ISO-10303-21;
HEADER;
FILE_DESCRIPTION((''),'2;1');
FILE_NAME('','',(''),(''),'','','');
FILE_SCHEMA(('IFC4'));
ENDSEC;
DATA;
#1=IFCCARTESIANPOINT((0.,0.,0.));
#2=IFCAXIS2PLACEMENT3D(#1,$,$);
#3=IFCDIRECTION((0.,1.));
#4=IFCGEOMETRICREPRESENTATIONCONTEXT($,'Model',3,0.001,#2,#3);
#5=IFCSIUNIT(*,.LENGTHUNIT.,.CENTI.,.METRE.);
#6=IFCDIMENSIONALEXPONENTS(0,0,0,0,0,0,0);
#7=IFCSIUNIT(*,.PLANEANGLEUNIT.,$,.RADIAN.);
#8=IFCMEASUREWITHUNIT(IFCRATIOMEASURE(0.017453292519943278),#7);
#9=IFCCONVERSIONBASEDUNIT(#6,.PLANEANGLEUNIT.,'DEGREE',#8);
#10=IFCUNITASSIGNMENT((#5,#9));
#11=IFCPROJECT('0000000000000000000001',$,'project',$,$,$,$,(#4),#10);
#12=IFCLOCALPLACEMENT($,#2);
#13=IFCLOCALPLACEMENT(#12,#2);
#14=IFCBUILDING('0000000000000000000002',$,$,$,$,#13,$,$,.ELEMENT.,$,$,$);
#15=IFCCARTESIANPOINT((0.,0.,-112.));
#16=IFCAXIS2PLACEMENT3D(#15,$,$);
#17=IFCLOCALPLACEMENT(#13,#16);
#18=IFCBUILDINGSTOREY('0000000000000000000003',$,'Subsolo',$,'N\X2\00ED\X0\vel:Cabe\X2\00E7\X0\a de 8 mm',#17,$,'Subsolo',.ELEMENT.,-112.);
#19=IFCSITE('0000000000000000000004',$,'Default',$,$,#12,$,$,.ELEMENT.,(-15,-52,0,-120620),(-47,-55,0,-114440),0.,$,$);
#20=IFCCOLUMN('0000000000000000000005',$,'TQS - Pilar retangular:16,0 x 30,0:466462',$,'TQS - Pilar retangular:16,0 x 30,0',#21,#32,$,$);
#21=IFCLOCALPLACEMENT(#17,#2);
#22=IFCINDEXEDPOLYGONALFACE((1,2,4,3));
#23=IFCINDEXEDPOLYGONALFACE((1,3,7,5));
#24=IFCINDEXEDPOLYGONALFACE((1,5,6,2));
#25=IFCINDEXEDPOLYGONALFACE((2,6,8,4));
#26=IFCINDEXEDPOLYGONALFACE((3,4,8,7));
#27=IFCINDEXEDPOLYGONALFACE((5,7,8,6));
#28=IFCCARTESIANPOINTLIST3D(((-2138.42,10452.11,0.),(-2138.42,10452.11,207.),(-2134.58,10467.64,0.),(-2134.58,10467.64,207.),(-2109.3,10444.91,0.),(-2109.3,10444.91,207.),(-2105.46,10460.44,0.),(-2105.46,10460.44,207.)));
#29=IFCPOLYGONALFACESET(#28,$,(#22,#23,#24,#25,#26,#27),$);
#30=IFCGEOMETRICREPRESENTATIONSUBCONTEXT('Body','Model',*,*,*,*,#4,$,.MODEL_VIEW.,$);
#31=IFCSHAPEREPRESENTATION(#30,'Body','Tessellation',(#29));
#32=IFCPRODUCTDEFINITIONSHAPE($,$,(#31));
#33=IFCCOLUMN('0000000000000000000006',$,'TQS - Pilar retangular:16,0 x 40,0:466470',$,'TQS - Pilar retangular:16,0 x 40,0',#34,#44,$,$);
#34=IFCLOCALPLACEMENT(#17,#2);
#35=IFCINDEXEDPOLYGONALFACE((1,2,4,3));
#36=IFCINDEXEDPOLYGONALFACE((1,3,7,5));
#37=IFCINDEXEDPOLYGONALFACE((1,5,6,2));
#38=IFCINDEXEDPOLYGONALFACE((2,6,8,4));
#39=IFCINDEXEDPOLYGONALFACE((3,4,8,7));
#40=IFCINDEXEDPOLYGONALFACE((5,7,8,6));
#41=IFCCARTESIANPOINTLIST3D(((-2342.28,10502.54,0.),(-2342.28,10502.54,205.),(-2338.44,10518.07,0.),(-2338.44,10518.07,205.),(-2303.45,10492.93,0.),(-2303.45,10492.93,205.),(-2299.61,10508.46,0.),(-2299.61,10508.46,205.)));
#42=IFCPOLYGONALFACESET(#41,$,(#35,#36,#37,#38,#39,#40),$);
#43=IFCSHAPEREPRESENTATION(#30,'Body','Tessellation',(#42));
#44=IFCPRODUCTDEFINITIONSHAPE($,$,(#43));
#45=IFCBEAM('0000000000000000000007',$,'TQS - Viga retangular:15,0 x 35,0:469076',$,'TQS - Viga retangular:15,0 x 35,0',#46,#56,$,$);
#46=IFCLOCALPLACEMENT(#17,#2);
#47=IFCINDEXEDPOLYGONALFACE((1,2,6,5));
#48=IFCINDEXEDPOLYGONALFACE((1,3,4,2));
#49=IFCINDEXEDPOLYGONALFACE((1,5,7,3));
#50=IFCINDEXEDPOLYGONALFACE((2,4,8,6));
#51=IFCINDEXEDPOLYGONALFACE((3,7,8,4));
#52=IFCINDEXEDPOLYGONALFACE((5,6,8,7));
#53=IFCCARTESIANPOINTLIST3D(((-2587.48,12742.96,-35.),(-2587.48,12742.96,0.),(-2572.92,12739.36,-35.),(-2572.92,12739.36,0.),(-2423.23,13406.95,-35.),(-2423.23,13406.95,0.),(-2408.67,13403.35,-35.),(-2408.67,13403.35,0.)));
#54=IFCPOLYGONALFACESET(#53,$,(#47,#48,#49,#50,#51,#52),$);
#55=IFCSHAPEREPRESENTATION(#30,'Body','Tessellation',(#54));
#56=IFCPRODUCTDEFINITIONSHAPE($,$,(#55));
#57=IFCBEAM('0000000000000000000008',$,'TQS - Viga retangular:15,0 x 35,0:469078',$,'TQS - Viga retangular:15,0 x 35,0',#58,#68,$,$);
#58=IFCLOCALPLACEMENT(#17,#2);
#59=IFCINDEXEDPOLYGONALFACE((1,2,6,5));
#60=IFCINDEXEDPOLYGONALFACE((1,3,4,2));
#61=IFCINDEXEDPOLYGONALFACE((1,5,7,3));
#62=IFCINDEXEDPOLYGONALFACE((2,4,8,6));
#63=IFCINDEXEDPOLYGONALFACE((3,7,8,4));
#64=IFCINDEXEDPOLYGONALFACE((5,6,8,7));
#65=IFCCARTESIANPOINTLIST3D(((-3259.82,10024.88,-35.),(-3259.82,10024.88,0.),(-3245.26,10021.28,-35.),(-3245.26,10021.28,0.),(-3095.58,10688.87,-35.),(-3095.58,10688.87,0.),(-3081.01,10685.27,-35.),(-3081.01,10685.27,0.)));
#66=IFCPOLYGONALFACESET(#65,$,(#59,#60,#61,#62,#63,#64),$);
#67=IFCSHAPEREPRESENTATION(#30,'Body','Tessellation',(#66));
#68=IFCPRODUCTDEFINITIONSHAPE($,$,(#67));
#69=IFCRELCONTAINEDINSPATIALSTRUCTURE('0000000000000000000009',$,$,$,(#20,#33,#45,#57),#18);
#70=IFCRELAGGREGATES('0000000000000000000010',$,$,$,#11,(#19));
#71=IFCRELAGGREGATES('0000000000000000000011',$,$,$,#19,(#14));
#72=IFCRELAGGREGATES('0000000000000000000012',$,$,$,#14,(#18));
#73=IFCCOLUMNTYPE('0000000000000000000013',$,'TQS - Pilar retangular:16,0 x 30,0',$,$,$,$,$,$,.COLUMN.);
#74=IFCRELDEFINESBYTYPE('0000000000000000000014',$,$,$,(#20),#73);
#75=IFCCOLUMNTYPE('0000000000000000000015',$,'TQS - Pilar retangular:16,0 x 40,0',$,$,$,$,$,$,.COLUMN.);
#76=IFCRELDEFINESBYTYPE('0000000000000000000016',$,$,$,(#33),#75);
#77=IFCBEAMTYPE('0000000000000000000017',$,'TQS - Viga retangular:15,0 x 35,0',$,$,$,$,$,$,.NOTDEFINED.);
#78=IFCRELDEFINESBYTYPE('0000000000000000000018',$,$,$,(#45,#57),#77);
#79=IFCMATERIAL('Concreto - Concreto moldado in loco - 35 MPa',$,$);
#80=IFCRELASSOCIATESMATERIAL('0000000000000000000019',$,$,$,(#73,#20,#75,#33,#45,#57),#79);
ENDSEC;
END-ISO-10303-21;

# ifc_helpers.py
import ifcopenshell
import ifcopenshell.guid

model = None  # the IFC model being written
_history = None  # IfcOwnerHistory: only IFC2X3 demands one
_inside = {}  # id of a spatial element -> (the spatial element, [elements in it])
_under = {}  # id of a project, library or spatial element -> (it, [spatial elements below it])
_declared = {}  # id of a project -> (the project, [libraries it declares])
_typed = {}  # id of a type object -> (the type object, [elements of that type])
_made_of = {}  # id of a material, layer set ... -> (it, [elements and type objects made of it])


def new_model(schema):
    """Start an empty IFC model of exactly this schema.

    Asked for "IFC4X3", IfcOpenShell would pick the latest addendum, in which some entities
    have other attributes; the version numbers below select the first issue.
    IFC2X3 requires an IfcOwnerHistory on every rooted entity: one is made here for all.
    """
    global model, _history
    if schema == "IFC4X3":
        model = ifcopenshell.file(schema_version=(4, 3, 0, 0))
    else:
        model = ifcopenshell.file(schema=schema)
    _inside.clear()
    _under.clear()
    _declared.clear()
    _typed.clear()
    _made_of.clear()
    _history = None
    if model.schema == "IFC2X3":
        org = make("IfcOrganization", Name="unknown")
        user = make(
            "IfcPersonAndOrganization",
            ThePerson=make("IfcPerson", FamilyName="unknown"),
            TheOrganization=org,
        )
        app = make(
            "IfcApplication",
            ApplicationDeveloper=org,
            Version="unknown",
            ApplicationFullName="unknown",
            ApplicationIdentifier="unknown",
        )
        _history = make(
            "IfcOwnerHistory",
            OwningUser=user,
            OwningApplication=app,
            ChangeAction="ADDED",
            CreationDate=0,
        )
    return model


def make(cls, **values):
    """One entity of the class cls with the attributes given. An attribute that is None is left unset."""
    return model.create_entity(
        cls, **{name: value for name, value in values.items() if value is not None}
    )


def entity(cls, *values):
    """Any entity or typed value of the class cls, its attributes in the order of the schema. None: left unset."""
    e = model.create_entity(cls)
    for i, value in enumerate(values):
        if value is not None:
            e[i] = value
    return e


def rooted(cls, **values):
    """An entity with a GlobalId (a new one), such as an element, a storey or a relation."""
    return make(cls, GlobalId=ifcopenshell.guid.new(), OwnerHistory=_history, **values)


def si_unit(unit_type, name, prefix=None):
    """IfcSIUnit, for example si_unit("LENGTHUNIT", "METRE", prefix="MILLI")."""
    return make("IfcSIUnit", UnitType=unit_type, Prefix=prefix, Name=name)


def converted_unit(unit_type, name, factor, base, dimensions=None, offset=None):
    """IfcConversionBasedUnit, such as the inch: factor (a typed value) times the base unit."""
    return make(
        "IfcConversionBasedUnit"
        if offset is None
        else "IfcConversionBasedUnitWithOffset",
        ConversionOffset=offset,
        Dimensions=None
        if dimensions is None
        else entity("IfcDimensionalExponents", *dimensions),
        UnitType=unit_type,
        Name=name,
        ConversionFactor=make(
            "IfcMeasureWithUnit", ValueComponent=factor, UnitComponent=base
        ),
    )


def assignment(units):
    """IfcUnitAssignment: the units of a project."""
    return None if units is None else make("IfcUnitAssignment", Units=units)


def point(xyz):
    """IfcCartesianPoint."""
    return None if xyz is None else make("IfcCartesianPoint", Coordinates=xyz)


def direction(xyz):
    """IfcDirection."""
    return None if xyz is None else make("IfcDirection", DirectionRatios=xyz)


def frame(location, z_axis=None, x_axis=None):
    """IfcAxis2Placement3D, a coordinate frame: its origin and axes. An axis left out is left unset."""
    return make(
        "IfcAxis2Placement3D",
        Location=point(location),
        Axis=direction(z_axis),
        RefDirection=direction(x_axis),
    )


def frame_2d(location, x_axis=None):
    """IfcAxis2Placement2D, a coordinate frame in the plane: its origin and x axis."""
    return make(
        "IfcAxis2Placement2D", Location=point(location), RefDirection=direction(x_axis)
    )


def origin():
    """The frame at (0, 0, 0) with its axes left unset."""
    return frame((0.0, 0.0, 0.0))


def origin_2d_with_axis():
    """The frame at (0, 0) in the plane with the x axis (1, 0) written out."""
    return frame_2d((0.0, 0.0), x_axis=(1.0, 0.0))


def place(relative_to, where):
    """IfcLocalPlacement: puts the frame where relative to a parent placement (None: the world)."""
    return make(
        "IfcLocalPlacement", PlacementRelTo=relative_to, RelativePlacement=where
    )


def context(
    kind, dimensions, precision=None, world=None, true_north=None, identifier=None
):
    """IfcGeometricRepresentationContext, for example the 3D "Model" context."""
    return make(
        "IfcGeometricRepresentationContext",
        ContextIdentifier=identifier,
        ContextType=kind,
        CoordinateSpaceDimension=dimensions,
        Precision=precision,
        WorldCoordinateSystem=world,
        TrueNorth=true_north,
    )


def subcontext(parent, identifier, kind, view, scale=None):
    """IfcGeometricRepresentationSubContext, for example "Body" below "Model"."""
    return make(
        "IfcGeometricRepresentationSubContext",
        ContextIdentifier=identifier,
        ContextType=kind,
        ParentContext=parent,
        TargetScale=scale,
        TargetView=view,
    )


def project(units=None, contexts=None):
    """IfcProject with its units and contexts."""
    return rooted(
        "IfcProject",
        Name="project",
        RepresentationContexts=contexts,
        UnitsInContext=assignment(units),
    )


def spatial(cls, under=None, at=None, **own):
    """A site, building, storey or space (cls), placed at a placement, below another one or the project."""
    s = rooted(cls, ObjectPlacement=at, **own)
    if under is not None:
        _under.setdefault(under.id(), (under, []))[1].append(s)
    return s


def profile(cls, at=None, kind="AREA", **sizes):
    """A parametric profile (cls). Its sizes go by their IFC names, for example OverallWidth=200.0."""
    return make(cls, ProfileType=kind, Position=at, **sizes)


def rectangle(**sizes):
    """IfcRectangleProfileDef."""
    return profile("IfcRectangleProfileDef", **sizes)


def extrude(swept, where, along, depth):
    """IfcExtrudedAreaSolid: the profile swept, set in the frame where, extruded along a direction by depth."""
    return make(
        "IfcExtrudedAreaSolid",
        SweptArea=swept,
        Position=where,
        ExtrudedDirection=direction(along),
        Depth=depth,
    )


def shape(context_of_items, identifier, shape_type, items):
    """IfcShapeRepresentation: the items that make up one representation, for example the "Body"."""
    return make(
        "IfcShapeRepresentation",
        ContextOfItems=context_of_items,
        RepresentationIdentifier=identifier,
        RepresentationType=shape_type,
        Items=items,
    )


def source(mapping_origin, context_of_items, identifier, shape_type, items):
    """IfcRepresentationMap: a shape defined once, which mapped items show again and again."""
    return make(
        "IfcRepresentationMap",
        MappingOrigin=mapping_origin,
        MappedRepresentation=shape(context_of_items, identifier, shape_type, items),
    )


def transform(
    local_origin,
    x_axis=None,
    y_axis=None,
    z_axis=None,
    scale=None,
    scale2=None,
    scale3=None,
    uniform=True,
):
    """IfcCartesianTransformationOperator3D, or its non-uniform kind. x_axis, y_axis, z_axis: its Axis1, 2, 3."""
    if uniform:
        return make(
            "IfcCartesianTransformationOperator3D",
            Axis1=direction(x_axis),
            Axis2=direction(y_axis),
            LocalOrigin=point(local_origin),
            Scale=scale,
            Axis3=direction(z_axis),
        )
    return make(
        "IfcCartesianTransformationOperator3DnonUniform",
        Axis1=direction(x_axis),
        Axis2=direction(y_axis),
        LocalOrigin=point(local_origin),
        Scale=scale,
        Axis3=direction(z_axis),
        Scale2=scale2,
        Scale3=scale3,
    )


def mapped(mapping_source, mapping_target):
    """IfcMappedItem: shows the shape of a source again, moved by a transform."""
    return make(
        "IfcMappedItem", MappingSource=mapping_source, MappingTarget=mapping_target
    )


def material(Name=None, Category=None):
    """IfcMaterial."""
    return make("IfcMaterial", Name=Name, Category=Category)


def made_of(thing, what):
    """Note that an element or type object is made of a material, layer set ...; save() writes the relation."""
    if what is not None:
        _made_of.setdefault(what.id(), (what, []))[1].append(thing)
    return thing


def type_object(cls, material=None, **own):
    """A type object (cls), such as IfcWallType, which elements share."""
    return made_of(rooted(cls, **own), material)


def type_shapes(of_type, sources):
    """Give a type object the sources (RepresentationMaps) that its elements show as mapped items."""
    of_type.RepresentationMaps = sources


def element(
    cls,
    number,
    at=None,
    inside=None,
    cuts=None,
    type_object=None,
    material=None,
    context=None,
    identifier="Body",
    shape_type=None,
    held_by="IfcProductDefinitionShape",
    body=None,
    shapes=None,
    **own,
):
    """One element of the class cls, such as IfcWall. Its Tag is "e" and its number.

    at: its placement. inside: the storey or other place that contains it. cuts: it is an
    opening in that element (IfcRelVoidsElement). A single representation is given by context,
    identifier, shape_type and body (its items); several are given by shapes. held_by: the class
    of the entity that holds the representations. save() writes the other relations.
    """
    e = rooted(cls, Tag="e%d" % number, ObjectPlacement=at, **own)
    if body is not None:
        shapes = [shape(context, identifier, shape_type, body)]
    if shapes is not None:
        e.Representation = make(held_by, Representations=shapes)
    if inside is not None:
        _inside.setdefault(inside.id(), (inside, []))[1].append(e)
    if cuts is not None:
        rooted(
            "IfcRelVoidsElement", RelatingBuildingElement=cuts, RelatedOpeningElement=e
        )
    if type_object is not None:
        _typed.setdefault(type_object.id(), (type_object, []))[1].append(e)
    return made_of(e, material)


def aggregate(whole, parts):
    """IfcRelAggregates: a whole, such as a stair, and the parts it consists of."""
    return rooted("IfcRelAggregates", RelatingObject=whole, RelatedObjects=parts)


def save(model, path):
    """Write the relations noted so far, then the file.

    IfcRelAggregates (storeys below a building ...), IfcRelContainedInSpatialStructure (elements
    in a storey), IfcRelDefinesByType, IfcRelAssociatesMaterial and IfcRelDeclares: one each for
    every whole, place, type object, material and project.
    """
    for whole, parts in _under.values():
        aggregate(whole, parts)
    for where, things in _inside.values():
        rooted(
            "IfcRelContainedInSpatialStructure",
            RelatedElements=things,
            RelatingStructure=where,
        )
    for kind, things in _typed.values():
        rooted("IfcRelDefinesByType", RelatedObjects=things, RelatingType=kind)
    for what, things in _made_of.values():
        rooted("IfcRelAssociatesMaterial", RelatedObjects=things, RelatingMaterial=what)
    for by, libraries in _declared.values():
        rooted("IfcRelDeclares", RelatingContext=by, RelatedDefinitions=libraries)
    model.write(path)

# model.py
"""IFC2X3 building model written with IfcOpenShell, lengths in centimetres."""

from ifc_helpers import new_model, entity, si_unit, converted_unit, direction, frame, frame_2d, origin, origin_2d_with_axis, place, context, subcontext, project, spatial, rectangle, extrude, source, transform, mapped, material, type_object, type_shapes, element, save


model = new_model("IFC2X3")

# Units and contexts
model_context = context("Model", 3, precision=0.001, world=origin(), true_north=direction((0.0, 1.0)))
body_context = subcontext(model_context, "Body", "Model", "MODEL_VIEW")
ifc_project = project(units=[si_unit("LENGTHUNIT", "METRE", prefix="CENTI"), converted_unit("PLANEANGLEUNIT", "DEGREE", entity("IfcRatioMeasure", 0.017453292519943278), si_unit("PLANEANGLEUNIT", "RADIAN"), dimensions=[0, 0, 0, 0, 0, 0, 0])], contexts=[model_context])

# Site, building, storey
site_placement = place(None, origin())
site = spatial("IfcSite", under=ifc_project, at=site_placement, Name="Default", CompositionType="ELEMENT", RefLatitude=(-15, -52, 0, -120620), RefLongitude=(-47, -55, 0, -114440), RefElevation=0.0)
building_placement = place(site_placement, origin())
building = spatial("IfcBuilding", under=site, at=building_placement, CompositionType="ELEMENT")
storey_placement = place(building_placement, frame((0.0, 0.0, -112.0)))
storey = spatial("IfcBuildingStorey", under=building, at=storey_placement, Name="Subsolo", ObjectType="Nível:Cabeça de 8 mm", LongName="Subsolo", CompositionType="ELEMENT", Elevation=-112.0)

# Columns
ifc_material_1 = material(Name="Concreto - Concreto moldado in loco - 35 MPa")
column_type_1 = type_object("IfcColumnType", Name="TQS - Pilar retangular:16,0 x 30,0", PredefinedType="COLUMN", material=ifc_material_1)
shared_shape_1 = source(origin(), body_context, "Body", "SweptSolid", [
    extrude(rectangle(XDim=30.0, YDim=16.0, at=origin_2d_with_axis()), frame((-2121.94, 10456.27, -112.0), z_axis=(0.0, 0.0, 1.0), x_axis=(-0.970743, 0.240122, 0.0)), (0.0, 0.0, 1.0), 207.0),
])
type_shapes(column_type_1, [shared_shape_1])
column_1_placement = place(storey_placement, frame((0.0, 0.0, 112.0)))
element("IfcColumn", 1, at=column_1_placement, inside=storey, type_object=column_type_1, material=ifc_material_1, Name="TQS - Pilar retangular:16,0 x 30,0:466462", ObjectType="TQS - Pilar retangular:16,0 x 30,0", context=body_context, shape_type="MappedRepresentation", body=[
    mapped(shared_shape_1, transform((0.0, 0.0, 0.0), scale=1.0)),
])
column_type_2 = type_object("IfcColumnType", Name="TQS - Pilar retangular:16,0 x 40,0", PredefinedType="COLUMN", material=ifc_material_1)
shared_shape_2 = source(origin(), body_context, "Body", "SweptSolid", [
    extrude(rectangle(XDim=40.0, YDim=16.0, at=origin_2d_with_axis()), frame((-2320.94, 10505.5, -112.0), z_axis=(0.0, 0.0, 1.0), x_axis=(-0.970743, 0.240122, 0.0)), (0.0, 0.0, 1.0), 205.0),
])
type_shapes(column_type_2, [shared_shape_2])
column_2_placement = place(storey_placement, frame((0.0, 0.0, 112.0)))
element("IfcColumn", 2, at=column_2_placement, inside=storey, type_object=column_type_2, material=ifc_material_1, Name="TQS - Pilar retangular:16,0 x 40,0:466470", ObjectType="TQS - Pilar retangular:16,0 x 40,0", context=body_context, shape_type="MappedRepresentation", body=[
    mapped(shared_shape_2, transform((0.0, 0.0, 0.0), scale=1.0)),
])

# Beams
beam_type_1 = type_object("IfcBeamType", Name="TQS - Viga retangular:15,0 x 35,0", PredefinedType="NOTDEFINED")
beam_1_placement = place(storey_placement, frame((-2580.2, 12741.16, 0.0), z_axis=(0.0, 0.0, 1.0), x_axis=(0.240122, 0.970743, 0.0)))
element("IfcBeam", 3, at=beam_1_placement, inside=storey, type_object=beam_type_1, material=ifc_material_1, Name="TQS - Viga retangular:15,0 x 35,0:469076", ObjectType="TQS - Viga retangular:15,0 x 35,0", context=body_context, shape_type="SweptSolid", body=[
    extrude(rectangle(XDim=35.0, YDim=15.0, at=frame_2d((0.0, 0.0), x_axis=(1.0, 0.0))), frame((0.0, 0.0, -17.5), z_axis=(1.0, 0.0, 0.0), x_axis=(0.0, 0.0, -1.0)), (0.0, 0.0, 1.0), 684.0),
])
beam_2_placement = place(storey_placement, frame((-3252.54, 10023.08, 0.0), z_axis=(0.0, 0.0, 1.0), x_axis=(0.240122, 0.970743, 0.0)))
element("IfcBeam", 4, at=beam_2_placement, inside=storey, type_object=beam_type_1, material=ifc_material_1, Name="TQS - Viga retangular:15,0 x 35,0:469078", ObjectType="TQS - Viga retangular:15,0 x 35,0", context=body_context, shape_type="SweptSolid", body=[
    extrude(rectangle(XDim=35.0, YDim=15.0, at=frame_2d((0.0, 0.0), x_axis=(1.0, 0.0))), frame((0.0, 0.0, -17.5), z_axis=(1.0, 0.0, 0.0), x_axis=(0.0, 0.0, -1.0)), (0.0, 0.0, 1.0), 684.0),
])

save(model, "model.ifc")
